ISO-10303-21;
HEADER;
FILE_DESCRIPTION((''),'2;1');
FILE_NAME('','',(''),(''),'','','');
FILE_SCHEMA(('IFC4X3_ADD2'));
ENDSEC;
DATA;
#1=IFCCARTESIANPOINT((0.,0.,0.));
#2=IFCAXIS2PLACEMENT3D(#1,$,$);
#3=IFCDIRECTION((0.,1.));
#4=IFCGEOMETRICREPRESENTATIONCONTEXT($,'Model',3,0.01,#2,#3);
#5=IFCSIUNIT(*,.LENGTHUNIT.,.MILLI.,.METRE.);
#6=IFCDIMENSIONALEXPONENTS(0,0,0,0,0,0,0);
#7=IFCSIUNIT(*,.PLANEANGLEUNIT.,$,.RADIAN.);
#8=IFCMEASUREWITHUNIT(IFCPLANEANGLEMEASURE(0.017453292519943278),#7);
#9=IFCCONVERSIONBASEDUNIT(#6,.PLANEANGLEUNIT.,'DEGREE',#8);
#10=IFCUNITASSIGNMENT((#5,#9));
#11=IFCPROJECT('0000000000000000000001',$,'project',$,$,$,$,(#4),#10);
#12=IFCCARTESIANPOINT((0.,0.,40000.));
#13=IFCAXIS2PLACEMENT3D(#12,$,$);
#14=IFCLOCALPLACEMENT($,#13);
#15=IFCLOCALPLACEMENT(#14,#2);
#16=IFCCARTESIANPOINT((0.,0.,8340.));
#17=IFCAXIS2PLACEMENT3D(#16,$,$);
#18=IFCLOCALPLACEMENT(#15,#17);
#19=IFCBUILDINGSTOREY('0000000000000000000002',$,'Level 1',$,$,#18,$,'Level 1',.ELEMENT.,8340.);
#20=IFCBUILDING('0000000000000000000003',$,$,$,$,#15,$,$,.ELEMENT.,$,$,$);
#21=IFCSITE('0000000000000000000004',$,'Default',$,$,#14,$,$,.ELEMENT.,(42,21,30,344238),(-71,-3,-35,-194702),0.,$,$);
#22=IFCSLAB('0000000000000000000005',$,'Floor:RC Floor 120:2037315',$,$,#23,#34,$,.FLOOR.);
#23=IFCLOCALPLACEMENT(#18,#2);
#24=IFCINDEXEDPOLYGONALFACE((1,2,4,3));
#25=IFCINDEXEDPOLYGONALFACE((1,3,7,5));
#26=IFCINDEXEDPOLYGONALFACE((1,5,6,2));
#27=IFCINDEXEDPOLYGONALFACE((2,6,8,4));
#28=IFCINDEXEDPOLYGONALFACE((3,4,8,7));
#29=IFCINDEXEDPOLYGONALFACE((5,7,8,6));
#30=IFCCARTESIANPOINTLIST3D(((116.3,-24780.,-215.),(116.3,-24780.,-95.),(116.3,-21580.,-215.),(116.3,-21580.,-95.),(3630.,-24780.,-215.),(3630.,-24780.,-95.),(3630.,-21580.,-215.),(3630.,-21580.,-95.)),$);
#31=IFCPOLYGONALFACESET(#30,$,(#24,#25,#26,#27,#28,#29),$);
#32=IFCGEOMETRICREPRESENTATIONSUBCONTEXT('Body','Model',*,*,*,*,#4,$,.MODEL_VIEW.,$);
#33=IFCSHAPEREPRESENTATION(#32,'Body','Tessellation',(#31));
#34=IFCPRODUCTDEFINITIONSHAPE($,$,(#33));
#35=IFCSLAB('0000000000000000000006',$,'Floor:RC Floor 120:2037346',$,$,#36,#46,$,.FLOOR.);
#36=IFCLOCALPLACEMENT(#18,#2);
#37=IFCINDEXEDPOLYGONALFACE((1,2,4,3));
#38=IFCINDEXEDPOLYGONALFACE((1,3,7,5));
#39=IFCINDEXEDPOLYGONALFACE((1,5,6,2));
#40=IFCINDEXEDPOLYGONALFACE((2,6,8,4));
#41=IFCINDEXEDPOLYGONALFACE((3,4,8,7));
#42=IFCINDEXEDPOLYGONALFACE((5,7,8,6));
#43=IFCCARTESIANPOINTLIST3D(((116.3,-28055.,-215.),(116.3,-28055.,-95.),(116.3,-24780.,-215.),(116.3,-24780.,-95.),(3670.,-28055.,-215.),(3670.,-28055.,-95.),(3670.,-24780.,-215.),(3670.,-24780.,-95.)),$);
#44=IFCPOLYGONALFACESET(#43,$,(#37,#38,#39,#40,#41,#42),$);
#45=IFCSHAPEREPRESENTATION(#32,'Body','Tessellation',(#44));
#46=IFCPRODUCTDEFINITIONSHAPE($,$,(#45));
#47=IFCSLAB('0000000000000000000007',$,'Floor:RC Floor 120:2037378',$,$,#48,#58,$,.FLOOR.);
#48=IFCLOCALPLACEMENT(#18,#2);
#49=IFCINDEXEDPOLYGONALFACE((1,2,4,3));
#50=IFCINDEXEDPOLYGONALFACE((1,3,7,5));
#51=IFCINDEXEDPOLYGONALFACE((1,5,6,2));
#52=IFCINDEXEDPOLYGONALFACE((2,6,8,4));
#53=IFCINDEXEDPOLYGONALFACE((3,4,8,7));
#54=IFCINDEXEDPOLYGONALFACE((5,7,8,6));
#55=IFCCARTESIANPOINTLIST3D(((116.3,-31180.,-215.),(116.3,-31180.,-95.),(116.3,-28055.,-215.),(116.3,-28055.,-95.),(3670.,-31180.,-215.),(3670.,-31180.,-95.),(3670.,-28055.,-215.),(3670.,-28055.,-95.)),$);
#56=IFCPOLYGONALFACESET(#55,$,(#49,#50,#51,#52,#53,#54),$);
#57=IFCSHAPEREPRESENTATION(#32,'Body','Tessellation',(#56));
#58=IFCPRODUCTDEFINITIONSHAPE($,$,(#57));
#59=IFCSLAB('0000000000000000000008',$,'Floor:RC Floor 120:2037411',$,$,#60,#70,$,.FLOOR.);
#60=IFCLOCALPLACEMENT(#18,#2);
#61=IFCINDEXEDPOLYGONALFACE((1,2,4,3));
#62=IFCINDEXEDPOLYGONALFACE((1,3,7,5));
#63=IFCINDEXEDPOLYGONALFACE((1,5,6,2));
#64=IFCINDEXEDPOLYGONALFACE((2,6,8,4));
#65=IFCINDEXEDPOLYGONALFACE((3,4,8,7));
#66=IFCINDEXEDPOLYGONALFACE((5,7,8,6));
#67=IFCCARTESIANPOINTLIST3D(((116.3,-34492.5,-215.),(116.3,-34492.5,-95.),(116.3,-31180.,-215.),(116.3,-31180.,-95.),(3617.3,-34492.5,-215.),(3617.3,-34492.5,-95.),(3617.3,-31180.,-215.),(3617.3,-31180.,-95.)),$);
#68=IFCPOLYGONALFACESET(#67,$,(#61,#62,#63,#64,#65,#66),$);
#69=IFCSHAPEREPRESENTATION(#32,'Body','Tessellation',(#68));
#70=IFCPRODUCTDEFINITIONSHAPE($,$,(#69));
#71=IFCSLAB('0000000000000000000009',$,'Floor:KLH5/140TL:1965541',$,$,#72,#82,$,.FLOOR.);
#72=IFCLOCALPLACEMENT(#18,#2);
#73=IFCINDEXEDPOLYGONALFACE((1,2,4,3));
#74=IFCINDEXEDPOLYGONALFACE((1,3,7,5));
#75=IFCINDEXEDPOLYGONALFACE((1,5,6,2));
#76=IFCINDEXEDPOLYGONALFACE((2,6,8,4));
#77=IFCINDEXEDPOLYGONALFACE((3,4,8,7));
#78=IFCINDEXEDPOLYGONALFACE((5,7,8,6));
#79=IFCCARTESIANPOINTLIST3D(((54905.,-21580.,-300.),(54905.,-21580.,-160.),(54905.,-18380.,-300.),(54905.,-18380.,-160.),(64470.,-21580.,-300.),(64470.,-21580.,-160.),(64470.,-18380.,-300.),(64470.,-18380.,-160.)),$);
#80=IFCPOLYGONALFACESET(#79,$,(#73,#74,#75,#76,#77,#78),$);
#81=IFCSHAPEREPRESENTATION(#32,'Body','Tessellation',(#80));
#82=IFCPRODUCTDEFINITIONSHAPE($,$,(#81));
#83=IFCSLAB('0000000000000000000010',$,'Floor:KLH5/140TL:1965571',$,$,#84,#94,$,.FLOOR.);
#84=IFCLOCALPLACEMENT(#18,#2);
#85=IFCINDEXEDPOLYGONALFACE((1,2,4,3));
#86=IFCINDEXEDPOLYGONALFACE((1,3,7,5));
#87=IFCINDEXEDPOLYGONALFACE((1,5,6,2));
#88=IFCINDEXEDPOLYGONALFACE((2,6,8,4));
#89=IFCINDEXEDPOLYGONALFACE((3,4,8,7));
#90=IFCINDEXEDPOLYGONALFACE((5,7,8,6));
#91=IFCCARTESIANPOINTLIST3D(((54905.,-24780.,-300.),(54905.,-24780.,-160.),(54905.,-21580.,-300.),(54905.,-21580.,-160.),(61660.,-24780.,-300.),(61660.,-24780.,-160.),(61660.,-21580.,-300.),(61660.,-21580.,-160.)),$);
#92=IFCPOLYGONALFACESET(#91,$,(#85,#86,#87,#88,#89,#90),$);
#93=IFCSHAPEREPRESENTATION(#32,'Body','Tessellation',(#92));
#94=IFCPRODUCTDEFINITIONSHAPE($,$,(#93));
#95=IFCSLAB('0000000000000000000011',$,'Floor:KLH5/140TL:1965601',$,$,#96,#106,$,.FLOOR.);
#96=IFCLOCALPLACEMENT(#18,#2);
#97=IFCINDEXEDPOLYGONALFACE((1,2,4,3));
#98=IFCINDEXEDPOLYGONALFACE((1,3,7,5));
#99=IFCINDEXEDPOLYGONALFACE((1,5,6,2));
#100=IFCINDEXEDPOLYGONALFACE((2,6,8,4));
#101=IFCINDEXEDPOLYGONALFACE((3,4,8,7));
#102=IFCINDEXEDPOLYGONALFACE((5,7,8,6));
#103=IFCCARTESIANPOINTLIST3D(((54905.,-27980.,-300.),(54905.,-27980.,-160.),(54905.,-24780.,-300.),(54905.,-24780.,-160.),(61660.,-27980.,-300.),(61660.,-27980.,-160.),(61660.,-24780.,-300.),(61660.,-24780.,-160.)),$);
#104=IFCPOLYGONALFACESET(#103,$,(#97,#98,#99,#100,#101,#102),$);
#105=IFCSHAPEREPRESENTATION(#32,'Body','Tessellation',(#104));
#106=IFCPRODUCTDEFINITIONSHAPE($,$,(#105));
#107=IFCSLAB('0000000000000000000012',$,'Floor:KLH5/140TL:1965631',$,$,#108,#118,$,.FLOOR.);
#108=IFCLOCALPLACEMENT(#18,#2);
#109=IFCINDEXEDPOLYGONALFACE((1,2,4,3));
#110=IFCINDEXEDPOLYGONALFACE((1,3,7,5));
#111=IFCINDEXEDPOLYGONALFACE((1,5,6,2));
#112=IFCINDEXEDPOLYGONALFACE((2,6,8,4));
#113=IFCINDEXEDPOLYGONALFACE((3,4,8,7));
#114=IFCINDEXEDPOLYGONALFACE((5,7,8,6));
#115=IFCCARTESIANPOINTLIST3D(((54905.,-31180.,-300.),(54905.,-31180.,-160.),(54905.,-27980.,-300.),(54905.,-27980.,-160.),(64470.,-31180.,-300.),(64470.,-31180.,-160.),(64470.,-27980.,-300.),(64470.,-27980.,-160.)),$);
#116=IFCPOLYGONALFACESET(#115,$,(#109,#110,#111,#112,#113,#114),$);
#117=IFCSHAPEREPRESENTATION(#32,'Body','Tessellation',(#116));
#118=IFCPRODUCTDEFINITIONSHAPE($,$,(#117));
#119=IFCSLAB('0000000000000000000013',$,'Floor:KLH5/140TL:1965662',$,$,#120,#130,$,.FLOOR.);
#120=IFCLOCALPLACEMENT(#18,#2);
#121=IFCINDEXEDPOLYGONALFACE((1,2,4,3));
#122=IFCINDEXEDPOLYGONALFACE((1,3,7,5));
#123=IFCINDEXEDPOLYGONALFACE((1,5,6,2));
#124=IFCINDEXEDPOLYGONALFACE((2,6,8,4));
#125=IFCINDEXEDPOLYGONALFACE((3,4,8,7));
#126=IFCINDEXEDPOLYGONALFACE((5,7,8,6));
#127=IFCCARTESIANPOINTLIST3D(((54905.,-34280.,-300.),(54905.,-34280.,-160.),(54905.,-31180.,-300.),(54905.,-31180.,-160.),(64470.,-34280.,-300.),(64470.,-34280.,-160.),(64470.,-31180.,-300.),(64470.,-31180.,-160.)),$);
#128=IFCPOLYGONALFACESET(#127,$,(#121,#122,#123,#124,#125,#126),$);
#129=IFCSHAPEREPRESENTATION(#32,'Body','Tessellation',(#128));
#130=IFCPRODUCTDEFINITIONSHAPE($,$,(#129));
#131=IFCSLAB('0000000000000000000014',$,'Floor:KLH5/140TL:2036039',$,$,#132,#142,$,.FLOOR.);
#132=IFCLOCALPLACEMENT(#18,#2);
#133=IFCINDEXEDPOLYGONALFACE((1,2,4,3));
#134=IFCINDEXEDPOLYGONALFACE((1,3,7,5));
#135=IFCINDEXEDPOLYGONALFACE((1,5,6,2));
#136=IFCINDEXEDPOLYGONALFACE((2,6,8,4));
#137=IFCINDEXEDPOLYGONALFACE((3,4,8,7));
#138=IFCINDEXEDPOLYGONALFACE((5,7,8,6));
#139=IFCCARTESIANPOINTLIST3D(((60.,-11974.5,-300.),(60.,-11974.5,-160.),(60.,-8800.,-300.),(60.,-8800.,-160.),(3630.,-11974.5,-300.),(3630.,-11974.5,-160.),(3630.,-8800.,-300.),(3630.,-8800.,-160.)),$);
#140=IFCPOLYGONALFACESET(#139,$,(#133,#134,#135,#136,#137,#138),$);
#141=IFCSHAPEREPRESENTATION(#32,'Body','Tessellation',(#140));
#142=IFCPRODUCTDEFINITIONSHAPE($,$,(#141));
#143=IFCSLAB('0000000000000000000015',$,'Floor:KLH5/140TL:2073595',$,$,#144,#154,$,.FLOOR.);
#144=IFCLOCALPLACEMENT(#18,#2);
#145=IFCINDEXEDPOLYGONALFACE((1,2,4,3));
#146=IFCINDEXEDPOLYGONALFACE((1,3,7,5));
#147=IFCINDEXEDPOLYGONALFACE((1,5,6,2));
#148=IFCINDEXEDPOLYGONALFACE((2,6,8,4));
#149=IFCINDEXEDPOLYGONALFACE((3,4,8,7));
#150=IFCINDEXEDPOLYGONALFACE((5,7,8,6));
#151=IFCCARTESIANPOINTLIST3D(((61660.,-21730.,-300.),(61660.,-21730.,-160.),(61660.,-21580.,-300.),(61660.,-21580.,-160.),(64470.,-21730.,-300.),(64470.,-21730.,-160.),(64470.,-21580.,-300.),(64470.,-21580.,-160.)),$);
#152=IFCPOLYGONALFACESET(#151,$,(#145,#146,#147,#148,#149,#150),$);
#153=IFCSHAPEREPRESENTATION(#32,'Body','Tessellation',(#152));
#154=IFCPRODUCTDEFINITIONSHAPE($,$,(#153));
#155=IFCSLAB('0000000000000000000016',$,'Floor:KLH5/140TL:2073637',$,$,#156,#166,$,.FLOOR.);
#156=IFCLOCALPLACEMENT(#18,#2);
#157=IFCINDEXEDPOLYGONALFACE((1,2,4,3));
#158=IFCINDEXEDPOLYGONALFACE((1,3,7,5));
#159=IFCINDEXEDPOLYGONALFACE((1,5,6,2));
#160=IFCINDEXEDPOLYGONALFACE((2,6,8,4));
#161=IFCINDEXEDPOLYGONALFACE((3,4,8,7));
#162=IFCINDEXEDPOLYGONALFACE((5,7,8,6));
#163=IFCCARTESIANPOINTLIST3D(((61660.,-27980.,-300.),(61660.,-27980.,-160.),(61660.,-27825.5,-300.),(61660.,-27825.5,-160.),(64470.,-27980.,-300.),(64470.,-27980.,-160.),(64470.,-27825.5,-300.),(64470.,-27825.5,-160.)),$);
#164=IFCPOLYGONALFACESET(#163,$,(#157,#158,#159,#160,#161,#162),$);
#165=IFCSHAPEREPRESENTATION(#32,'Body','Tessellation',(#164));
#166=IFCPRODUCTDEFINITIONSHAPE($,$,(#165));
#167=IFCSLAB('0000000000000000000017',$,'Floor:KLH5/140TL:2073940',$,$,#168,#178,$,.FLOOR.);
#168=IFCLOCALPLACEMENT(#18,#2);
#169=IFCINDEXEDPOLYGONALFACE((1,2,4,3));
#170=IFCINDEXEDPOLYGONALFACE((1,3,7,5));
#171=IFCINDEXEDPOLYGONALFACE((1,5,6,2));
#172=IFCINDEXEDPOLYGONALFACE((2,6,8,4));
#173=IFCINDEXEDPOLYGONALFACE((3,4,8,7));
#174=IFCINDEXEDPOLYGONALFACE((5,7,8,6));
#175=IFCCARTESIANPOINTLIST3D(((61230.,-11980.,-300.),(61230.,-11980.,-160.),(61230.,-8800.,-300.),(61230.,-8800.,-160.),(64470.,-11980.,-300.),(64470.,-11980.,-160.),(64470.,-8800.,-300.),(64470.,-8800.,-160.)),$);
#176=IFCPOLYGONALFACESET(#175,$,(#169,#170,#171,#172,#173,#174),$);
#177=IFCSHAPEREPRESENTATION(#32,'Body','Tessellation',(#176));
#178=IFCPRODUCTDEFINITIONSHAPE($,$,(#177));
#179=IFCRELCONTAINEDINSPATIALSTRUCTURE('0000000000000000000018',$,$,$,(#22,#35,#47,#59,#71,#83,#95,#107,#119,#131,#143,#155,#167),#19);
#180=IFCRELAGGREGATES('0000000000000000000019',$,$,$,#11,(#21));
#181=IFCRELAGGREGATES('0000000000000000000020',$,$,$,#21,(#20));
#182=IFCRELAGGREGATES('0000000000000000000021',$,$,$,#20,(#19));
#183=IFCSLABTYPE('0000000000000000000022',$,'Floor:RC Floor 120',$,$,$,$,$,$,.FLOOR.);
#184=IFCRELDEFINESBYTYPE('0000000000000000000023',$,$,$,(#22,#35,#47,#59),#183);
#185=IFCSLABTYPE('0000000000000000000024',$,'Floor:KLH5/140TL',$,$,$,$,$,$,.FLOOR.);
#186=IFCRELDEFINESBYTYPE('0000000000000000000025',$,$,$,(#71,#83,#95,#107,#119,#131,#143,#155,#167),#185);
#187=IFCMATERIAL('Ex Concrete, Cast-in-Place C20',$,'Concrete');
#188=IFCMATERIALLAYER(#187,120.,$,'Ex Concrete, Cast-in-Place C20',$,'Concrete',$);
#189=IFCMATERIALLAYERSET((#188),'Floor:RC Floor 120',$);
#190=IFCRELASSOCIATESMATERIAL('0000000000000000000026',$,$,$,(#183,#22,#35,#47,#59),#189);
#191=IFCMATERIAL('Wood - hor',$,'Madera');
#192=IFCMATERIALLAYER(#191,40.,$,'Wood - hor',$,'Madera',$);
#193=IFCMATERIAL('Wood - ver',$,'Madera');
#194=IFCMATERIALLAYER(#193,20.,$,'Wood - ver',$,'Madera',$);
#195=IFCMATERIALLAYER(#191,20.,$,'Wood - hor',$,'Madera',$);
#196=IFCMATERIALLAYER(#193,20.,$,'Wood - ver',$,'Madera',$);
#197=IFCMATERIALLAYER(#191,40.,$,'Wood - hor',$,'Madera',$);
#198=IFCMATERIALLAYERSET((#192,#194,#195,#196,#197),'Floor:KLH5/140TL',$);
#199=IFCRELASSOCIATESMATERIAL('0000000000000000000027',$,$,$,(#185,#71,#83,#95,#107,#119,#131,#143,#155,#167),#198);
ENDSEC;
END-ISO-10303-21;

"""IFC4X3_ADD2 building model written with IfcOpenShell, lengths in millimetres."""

from ifc_helpers import new_model, entity, si_unit, converted_unit, direction, frame, frame_2d, origin, origin_2d_with_axis, place, context, subcontext, project, spatial, rectangle, extrude, material, layer, layer_set, layer_usage, type_object, element, save


model = new_model("IFC4X3_ADD2")

# Units and contexts
model_context = context("Model", 3, precision=0.01, world=origin(), true_north=direction((0.0, 1.0)))
body_context = subcontext(model_context, "Body", "Model", "MODEL_VIEW")
ifc_project = project(units=[si_unit("LENGTHUNIT", "METRE", prefix="MILLI"), converted_unit("PLANEANGLEUNIT", "DEGREE", entity("IfcPlaneAngleMeasure", 0.017453292519943278), si_unit("PLANEANGLEUNIT", "RADIAN"), dimensions=[0, 0, 0, 0, 0, 0, 0])], contexts=[model_context])

# Site, building, storey
site_placement = place(None, frame((0.0, 0.0, 40000.0)))
site = spatial("IfcSite", under=ifc_project, at=site_placement, Name="Default", CompositionType="ELEMENT", RefLatitude=(42, 21, 30, 344238), RefLongitude=(-71, -3, -35, -194702), RefElevation=0.0)
building_placement = place(site_placement, origin())
building = spatial("IfcBuilding", under=site, at=building_placement, CompositionType="ELEMENT")
storey_placement = place(building_placement, frame((0.0, 0.0, 8340.0)))
storey = spatial("IfcBuildingStorey", under=building, at=storey_placement, Name="Level 1", LongName="Level 1", CompositionType="ELEMENT", Elevation=8340.0)

# Slabs
ifc_material_1 = material(Name="Ex Concrete, Cast-in-Place C20", Category="Concrete")
ifc_layer_1 = layer(ifc_material_1, 120.0, Name="Ex Concrete, Cast-in-Place C20", Category="Concrete")
ifc_layer_set_1 = layer_set([ifc_layer_1], Name="Floor:RC Floor 120")
slab_type_1 = type_object("IfcSlabType", Name="Floor:RC Floor 120", PredefinedType="FLOOR", material=ifc_layer_set_1)
ifc_layer_usage_1 = layer_usage(ifc_layer_set_1, "AXIS3", "POSITIVE", 0.0)
slab_1_placement = place(storey_placement, origin())
element("IfcSlab", 1, at=slab_1_placement, inside=storey, type_object=slab_type_1, material=ifc_layer_usage_1, Name="Floor:RC Floor 120:2037315", PredefinedType="FLOOR", context=body_context, shape_type="SweptSolid", body=[
    extrude(rectangle(XDim=3200.0, YDim=3513.7, at=origin_2d_with_axis()), frame((1873.2, -23180.0, -95.0), z_axis=(0.0, 0.0, -1.0), x_axis=(0.0, 1.0, 0.0)), (0.0, 0.0, 1.0), 120.0),
])
ifc_layer_usage_2 = layer_usage(ifc_layer_set_1, "AXIS3", "POSITIVE", 0.0)
slab_2_placement = place(storey_placement, origin())
element("IfcSlab", 2, at=slab_2_placement, inside=storey, type_object=slab_type_1, material=ifc_layer_usage_2, Name="Floor:RC Floor 120:2037346", PredefinedType="FLOOR", context=body_context, shape_type="SweptSolid", body=[
    extrude(rectangle(XDim=3275.0, YDim=3553.7, at=frame_2d((0.0, 0.0), x_axis=(1.0, 0.0))), frame((1893.2, -26417.5, -95.0), z_axis=(0.0, 0.0, -1.0), x_axis=(0.0, 1.0, 0.0)), (0.0, 0.0, 1.0), 120.0),
])
ifc_layer_usage_3 = layer_usage(ifc_layer_set_1, "AXIS3", "POSITIVE", 0.0)
slab_3_placement = place(storey_placement, origin())
element("IfcSlab", 3, at=slab_3_placement, inside=storey, type_object=slab_type_1, material=ifc_layer_usage_3, Name="Floor:RC Floor 120:2037378", PredefinedType="FLOOR", context=body_context, shape_type="SweptSolid", body=[
    extrude(rectangle(XDim=3125.0, YDim=3553.7, at=frame_2d((0.0, 0.0), x_axis=(1.0, 0.0))), frame((1893.2, -29617.5, -95.0), z_axis=(0.0, 0.0, -1.0), x_axis=(0.0, 1.0, 0.0)), (0.0, 0.0, 1.0), 120.0),
])
ifc_layer_usage_4 = layer_usage(ifc_layer_set_1, "AXIS3", "POSITIVE", 0.0)
slab_4_placement = place(storey_placement, origin())
element("IfcSlab", 4, at=slab_4_placement, inside=storey, type_object=slab_type_1, material=ifc_layer_usage_4, Name="Floor:RC Floor 120:2037411", PredefinedType="FLOOR", context=body_context, shape_type="SweptSolid", body=[
    extrude(rectangle(XDim=3312.5, YDim=3501.0, at=frame_2d((0.0, 0.0), x_axis=(1.0, 0.0))), frame((1866.8, -32836.3, -95.0), z_axis=(0.0, 0.0, -1.0), x_axis=(0.0, 1.0, 0.0)), (0.0, 0.0, 1.0), 120.0),
])
ifc_material_2 = material(Name="Wood - hor", Category="Madera")
ifc_layer_2 = layer(ifc_material_2, 40.0, Name="Wood - hor", Category="Madera")
ifc_material_3 = material(Name="Wood - ver", Category="Madera")
ifc_layer_3 = layer(ifc_material_3, 20.0, Name="Wood - ver", Category="Madera")
ifc_layer_4 = layer(ifc_material_2, 20.0, Name="Wood - hor", Category="Madera")
ifc_layer_5 = layer(ifc_material_3, 20.0, Name="Wood - ver", Category="Madera")
ifc_layer_6 = layer(ifc_material_2, 40.0, Name="Wood - hor", Category="Madera")
ifc_layer_set_2 = layer_set([ifc_layer_2, ifc_layer_3, ifc_layer_4, ifc_layer_5, ifc_layer_6], Name="Floor:KLH5/140TL")
ifc_layer_usage_5 = layer_usage(ifc_layer_set_2, "AXIS3", "POSITIVE", 0.0)
slab_type_2 = type_object("IfcSlabType", Name="Floor:KLH5/140TL", PredefinedType="FLOOR", material=ifc_layer_set_2)
slab_5_placement = place(storey_placement, origin())
element("IfcSlab", 5, at=slab_5_placement, inside=storey, type_object=slab_type_2, material=ifc_layer_usage_5, Name="Floor:KLH5/140TL:1965541", PredefinedType="FLOOR", context=body_context, shape_type="SweptSolid", body=[
    extrude(rectangle(XDim=3200.0, YDim=9565.0, at=frame_2d((0.0, 0.0), x_axis=(1.0, 0.0))), frame((59687.5, -19980.0, -160.0), z_axis=(0.0, 0.0, -1.0), x_axis=(0.0, 1.0, 0.0)), (0.0, 0.0, 1.0), 140.0),
])
ifc_layer_usage_6 = layer_usage(ifc_layer_set_2, "AXIS3", "POSITIVE", 0.0)
slab_6_placement = place(storey_placement, origin())
element("IfcSlab", 6, at=slab_6_placement, inside=storey, type_object=slab_type_2, material=ifc_layer_usage_6, Name="Floor:KLH5/140TL:1965571", PredefinedType="FLOOR", context=body_context, shape_type="SweptSolid", body=[
    extrude(rectangle(XDim=3200.0, YDim=6755.0, at=frame_2d((0.0, 0.0), x_axis=(1.0, 0.0))), frame((58282.5, -23180.0, -160.0), z_axis=(0.0, 0.0, -1.0), x_axis=(0.0, 1.0, 0.0)), (0.0, 0.0, 1.0), 140.0),
])
ifc_layer_usage_7 = layer_usage(ifc_layer_set_2, "AXIS3", "POSITIVE", 0.0)
slab_7_placement = place(storey_placement, origin())
element("IfcSlab", 7, at=slab_7_placement, inside=storey, type_object=slab_type_2, material=ifc_layer_usage_7, Name="Floor:KLH5/140TL:1965601", PredefinedType="FLOOR", context=body_context, shape_type="SweptSolid", body=[
    extrude(rectangle(XDim=3200.0, YDim=6755.0, at=frame_2d((0.0, 0.0), x_axis=(1.0, 0.0))), frame((58282.5, -26380.0, -160.0), z_axis=(0.0, 0.0, -1.0), x_axis=(0.0, 1.0, 0.0)), (0.0, 0.0, 1.0), 140.0),
])
ifc_layer_usage_8 = layer_usage(ifc_layer_set_2, "AXIS3", "POSITIVE", 0.0)
slab_8_placement = place(storey_placement, origin())
element("IfcSlab", 8, at=slab_8_placement, inside=storey, type_object=slab_type_2, material=ifc_layer_usage_8, Name="Floor:KLH5/140TL:1965631", PredefinedType="FLOOR", context=body_context, shape_type="SweptSolid", body=[
    extrude(rectangle(XDim=3200.0, YDim=9565.0, at=frame_2d((0.0, 0.0), x_axis=(1.0, 0.0))), frame((59687.5, -29580.0, -160.0), z_axis=(0.0, 0.0, -1.0), x_axis=(0.0, 1.0, 0.0)), (0.0, 0.0, 1.0), 140.0),
])
ifc_layer_usage_9 = layer_usage(ifc_layer_set_2, "AXIS3", "POSITIVE", 0.0)
slab_9_placement = place(storey_placement, origin())
element("IfcSlab", 9, at=slab_9_placement, inside=storey, type_object=slab_type_2, material=ifc_layer_usage_9, Name="Floor:KLH5/140TL:1965662", PredefinedType="FLOOR", context=body_context, shape_type="SweptSolid", body=[
    extrude(rectangle(XDim=3100.0, YDim=9565.0, at=frame_2d((0.0, 0.0), x_axis=(1.0, 0.0))), frame((59687.5, -32730.0, -160.0), z_axis=(0.0, 0.0, -1.0), x_axis=(0.0, 1.0, 0.0)), (0.0, 0.0, 1.0), 140.0),
])
ifc_layer_usage_10 = layer_usage(ifc_layer_set_2, "AXIS3", "POSITIVE", 0.0)
slab_10_placement = place(storey_placement, origin())
element("IfcSlab", 10, at=slab_10_placement, inside=storey, type_object=slab_type_2, material=ifc_layer_usage_10, Name="Floor:KLH5/140TL:2036039", PredefinedType="FLOOR", context=body_context, shape_type="SweptSolid", body=[
    extrude(rectangle(XDim=3174.5, YDim=3570.0, at=frame_2d((0.0, 0.0), x_axis=(1.0, 0.0))), frame((1845.0, -10387.3, -160.0), z_axis=(0.0, 0.0, -1.0), x_axis=(0.0, 1.0, 0.0)), (0.0, 0.0, 1.0), 140.0),
])
ifc_layer_usage_11 = layer_usage(ifc_layer_set_2, "AXIS3", "POSITIVE", 0.0)
slab_11_placement = place(storey_placement, origin())
element("IfcSlab", 11, at=slab_11_placement, inside=storey, type_object=slab_type_2, material=ifc_layer_usage_11, Name="Floor:KLH5/140TL:2073595", PredefinedType="FLOOR", context=body_context, shape_type="SweptSolid", body=[
    extrude(rectangle(XDim=150.0, YDim=2810.0, at=origin_2d_with_axis()), frame((63065.0, -21655.0, -160.0), z_axis=(0.0, 0.0, -1.0), x_axis=(0.0, 1.0, 0.0)), (0.0, 0.0, 1.0), 140.0),
])
ifc_layer_usage_12 = layer_usage(ifc_layer_set_2, "AXIS3", "POSITIVE", 0.0)
slab_12_placement = place(storey_placement, origin())
element("IfcSlab", 12, at=slab_12_placement, inside=storey, type_object=slab_type_2, material=ifc_layer_usage_12, Name="Floor:KLH5/140TL:2073637", PredefinedType="FLOOR", context=body_context, shape_type="SweptSolid", body=[
    extrude(rectangle(XDim=154.5, YDim=2810.0, at=frame_2d((0.0, 0.0), x_axis=(1.0, 0.0))), frame((63065.0, -27902.8, -160.0), z_axis=(0.0, 0.0, -1.0), x_axis=(0.0, 1.0, 0.0)), (0.0, 0.0, 1.0), 140.0),
])
ifc_layer_usage_13 = layer_usage(ifc_layer_set_2, "AXIS3", "POSITIVE", 0.0)
slab_13_placement = place(storey_placement, origin())
element("IfcSlab", 13, at=slab_13_placement, inside=storey, type_object=slab_type_2, material=ifc_layer_usage_13, Name="Floor:KLH5/140TL:2073940", PredefinedType="FLOOR", context=body_context, shape_type="SweptSolid", body=[
    extrude(rectangle(XDim=3180.0, YDim=3240.0, at=frame_2d((0.0, 0.0), x_axis=(1.0, 0.0))), frame((62850.0, -10390.0, -160.0), z_axis=(0.0, 0.0, -1.0), x_axis=(0.0, 1.0, 0.0)), (0.0, 0.0, 1.0), 140.0),
])

save(model, "model.ifc")
